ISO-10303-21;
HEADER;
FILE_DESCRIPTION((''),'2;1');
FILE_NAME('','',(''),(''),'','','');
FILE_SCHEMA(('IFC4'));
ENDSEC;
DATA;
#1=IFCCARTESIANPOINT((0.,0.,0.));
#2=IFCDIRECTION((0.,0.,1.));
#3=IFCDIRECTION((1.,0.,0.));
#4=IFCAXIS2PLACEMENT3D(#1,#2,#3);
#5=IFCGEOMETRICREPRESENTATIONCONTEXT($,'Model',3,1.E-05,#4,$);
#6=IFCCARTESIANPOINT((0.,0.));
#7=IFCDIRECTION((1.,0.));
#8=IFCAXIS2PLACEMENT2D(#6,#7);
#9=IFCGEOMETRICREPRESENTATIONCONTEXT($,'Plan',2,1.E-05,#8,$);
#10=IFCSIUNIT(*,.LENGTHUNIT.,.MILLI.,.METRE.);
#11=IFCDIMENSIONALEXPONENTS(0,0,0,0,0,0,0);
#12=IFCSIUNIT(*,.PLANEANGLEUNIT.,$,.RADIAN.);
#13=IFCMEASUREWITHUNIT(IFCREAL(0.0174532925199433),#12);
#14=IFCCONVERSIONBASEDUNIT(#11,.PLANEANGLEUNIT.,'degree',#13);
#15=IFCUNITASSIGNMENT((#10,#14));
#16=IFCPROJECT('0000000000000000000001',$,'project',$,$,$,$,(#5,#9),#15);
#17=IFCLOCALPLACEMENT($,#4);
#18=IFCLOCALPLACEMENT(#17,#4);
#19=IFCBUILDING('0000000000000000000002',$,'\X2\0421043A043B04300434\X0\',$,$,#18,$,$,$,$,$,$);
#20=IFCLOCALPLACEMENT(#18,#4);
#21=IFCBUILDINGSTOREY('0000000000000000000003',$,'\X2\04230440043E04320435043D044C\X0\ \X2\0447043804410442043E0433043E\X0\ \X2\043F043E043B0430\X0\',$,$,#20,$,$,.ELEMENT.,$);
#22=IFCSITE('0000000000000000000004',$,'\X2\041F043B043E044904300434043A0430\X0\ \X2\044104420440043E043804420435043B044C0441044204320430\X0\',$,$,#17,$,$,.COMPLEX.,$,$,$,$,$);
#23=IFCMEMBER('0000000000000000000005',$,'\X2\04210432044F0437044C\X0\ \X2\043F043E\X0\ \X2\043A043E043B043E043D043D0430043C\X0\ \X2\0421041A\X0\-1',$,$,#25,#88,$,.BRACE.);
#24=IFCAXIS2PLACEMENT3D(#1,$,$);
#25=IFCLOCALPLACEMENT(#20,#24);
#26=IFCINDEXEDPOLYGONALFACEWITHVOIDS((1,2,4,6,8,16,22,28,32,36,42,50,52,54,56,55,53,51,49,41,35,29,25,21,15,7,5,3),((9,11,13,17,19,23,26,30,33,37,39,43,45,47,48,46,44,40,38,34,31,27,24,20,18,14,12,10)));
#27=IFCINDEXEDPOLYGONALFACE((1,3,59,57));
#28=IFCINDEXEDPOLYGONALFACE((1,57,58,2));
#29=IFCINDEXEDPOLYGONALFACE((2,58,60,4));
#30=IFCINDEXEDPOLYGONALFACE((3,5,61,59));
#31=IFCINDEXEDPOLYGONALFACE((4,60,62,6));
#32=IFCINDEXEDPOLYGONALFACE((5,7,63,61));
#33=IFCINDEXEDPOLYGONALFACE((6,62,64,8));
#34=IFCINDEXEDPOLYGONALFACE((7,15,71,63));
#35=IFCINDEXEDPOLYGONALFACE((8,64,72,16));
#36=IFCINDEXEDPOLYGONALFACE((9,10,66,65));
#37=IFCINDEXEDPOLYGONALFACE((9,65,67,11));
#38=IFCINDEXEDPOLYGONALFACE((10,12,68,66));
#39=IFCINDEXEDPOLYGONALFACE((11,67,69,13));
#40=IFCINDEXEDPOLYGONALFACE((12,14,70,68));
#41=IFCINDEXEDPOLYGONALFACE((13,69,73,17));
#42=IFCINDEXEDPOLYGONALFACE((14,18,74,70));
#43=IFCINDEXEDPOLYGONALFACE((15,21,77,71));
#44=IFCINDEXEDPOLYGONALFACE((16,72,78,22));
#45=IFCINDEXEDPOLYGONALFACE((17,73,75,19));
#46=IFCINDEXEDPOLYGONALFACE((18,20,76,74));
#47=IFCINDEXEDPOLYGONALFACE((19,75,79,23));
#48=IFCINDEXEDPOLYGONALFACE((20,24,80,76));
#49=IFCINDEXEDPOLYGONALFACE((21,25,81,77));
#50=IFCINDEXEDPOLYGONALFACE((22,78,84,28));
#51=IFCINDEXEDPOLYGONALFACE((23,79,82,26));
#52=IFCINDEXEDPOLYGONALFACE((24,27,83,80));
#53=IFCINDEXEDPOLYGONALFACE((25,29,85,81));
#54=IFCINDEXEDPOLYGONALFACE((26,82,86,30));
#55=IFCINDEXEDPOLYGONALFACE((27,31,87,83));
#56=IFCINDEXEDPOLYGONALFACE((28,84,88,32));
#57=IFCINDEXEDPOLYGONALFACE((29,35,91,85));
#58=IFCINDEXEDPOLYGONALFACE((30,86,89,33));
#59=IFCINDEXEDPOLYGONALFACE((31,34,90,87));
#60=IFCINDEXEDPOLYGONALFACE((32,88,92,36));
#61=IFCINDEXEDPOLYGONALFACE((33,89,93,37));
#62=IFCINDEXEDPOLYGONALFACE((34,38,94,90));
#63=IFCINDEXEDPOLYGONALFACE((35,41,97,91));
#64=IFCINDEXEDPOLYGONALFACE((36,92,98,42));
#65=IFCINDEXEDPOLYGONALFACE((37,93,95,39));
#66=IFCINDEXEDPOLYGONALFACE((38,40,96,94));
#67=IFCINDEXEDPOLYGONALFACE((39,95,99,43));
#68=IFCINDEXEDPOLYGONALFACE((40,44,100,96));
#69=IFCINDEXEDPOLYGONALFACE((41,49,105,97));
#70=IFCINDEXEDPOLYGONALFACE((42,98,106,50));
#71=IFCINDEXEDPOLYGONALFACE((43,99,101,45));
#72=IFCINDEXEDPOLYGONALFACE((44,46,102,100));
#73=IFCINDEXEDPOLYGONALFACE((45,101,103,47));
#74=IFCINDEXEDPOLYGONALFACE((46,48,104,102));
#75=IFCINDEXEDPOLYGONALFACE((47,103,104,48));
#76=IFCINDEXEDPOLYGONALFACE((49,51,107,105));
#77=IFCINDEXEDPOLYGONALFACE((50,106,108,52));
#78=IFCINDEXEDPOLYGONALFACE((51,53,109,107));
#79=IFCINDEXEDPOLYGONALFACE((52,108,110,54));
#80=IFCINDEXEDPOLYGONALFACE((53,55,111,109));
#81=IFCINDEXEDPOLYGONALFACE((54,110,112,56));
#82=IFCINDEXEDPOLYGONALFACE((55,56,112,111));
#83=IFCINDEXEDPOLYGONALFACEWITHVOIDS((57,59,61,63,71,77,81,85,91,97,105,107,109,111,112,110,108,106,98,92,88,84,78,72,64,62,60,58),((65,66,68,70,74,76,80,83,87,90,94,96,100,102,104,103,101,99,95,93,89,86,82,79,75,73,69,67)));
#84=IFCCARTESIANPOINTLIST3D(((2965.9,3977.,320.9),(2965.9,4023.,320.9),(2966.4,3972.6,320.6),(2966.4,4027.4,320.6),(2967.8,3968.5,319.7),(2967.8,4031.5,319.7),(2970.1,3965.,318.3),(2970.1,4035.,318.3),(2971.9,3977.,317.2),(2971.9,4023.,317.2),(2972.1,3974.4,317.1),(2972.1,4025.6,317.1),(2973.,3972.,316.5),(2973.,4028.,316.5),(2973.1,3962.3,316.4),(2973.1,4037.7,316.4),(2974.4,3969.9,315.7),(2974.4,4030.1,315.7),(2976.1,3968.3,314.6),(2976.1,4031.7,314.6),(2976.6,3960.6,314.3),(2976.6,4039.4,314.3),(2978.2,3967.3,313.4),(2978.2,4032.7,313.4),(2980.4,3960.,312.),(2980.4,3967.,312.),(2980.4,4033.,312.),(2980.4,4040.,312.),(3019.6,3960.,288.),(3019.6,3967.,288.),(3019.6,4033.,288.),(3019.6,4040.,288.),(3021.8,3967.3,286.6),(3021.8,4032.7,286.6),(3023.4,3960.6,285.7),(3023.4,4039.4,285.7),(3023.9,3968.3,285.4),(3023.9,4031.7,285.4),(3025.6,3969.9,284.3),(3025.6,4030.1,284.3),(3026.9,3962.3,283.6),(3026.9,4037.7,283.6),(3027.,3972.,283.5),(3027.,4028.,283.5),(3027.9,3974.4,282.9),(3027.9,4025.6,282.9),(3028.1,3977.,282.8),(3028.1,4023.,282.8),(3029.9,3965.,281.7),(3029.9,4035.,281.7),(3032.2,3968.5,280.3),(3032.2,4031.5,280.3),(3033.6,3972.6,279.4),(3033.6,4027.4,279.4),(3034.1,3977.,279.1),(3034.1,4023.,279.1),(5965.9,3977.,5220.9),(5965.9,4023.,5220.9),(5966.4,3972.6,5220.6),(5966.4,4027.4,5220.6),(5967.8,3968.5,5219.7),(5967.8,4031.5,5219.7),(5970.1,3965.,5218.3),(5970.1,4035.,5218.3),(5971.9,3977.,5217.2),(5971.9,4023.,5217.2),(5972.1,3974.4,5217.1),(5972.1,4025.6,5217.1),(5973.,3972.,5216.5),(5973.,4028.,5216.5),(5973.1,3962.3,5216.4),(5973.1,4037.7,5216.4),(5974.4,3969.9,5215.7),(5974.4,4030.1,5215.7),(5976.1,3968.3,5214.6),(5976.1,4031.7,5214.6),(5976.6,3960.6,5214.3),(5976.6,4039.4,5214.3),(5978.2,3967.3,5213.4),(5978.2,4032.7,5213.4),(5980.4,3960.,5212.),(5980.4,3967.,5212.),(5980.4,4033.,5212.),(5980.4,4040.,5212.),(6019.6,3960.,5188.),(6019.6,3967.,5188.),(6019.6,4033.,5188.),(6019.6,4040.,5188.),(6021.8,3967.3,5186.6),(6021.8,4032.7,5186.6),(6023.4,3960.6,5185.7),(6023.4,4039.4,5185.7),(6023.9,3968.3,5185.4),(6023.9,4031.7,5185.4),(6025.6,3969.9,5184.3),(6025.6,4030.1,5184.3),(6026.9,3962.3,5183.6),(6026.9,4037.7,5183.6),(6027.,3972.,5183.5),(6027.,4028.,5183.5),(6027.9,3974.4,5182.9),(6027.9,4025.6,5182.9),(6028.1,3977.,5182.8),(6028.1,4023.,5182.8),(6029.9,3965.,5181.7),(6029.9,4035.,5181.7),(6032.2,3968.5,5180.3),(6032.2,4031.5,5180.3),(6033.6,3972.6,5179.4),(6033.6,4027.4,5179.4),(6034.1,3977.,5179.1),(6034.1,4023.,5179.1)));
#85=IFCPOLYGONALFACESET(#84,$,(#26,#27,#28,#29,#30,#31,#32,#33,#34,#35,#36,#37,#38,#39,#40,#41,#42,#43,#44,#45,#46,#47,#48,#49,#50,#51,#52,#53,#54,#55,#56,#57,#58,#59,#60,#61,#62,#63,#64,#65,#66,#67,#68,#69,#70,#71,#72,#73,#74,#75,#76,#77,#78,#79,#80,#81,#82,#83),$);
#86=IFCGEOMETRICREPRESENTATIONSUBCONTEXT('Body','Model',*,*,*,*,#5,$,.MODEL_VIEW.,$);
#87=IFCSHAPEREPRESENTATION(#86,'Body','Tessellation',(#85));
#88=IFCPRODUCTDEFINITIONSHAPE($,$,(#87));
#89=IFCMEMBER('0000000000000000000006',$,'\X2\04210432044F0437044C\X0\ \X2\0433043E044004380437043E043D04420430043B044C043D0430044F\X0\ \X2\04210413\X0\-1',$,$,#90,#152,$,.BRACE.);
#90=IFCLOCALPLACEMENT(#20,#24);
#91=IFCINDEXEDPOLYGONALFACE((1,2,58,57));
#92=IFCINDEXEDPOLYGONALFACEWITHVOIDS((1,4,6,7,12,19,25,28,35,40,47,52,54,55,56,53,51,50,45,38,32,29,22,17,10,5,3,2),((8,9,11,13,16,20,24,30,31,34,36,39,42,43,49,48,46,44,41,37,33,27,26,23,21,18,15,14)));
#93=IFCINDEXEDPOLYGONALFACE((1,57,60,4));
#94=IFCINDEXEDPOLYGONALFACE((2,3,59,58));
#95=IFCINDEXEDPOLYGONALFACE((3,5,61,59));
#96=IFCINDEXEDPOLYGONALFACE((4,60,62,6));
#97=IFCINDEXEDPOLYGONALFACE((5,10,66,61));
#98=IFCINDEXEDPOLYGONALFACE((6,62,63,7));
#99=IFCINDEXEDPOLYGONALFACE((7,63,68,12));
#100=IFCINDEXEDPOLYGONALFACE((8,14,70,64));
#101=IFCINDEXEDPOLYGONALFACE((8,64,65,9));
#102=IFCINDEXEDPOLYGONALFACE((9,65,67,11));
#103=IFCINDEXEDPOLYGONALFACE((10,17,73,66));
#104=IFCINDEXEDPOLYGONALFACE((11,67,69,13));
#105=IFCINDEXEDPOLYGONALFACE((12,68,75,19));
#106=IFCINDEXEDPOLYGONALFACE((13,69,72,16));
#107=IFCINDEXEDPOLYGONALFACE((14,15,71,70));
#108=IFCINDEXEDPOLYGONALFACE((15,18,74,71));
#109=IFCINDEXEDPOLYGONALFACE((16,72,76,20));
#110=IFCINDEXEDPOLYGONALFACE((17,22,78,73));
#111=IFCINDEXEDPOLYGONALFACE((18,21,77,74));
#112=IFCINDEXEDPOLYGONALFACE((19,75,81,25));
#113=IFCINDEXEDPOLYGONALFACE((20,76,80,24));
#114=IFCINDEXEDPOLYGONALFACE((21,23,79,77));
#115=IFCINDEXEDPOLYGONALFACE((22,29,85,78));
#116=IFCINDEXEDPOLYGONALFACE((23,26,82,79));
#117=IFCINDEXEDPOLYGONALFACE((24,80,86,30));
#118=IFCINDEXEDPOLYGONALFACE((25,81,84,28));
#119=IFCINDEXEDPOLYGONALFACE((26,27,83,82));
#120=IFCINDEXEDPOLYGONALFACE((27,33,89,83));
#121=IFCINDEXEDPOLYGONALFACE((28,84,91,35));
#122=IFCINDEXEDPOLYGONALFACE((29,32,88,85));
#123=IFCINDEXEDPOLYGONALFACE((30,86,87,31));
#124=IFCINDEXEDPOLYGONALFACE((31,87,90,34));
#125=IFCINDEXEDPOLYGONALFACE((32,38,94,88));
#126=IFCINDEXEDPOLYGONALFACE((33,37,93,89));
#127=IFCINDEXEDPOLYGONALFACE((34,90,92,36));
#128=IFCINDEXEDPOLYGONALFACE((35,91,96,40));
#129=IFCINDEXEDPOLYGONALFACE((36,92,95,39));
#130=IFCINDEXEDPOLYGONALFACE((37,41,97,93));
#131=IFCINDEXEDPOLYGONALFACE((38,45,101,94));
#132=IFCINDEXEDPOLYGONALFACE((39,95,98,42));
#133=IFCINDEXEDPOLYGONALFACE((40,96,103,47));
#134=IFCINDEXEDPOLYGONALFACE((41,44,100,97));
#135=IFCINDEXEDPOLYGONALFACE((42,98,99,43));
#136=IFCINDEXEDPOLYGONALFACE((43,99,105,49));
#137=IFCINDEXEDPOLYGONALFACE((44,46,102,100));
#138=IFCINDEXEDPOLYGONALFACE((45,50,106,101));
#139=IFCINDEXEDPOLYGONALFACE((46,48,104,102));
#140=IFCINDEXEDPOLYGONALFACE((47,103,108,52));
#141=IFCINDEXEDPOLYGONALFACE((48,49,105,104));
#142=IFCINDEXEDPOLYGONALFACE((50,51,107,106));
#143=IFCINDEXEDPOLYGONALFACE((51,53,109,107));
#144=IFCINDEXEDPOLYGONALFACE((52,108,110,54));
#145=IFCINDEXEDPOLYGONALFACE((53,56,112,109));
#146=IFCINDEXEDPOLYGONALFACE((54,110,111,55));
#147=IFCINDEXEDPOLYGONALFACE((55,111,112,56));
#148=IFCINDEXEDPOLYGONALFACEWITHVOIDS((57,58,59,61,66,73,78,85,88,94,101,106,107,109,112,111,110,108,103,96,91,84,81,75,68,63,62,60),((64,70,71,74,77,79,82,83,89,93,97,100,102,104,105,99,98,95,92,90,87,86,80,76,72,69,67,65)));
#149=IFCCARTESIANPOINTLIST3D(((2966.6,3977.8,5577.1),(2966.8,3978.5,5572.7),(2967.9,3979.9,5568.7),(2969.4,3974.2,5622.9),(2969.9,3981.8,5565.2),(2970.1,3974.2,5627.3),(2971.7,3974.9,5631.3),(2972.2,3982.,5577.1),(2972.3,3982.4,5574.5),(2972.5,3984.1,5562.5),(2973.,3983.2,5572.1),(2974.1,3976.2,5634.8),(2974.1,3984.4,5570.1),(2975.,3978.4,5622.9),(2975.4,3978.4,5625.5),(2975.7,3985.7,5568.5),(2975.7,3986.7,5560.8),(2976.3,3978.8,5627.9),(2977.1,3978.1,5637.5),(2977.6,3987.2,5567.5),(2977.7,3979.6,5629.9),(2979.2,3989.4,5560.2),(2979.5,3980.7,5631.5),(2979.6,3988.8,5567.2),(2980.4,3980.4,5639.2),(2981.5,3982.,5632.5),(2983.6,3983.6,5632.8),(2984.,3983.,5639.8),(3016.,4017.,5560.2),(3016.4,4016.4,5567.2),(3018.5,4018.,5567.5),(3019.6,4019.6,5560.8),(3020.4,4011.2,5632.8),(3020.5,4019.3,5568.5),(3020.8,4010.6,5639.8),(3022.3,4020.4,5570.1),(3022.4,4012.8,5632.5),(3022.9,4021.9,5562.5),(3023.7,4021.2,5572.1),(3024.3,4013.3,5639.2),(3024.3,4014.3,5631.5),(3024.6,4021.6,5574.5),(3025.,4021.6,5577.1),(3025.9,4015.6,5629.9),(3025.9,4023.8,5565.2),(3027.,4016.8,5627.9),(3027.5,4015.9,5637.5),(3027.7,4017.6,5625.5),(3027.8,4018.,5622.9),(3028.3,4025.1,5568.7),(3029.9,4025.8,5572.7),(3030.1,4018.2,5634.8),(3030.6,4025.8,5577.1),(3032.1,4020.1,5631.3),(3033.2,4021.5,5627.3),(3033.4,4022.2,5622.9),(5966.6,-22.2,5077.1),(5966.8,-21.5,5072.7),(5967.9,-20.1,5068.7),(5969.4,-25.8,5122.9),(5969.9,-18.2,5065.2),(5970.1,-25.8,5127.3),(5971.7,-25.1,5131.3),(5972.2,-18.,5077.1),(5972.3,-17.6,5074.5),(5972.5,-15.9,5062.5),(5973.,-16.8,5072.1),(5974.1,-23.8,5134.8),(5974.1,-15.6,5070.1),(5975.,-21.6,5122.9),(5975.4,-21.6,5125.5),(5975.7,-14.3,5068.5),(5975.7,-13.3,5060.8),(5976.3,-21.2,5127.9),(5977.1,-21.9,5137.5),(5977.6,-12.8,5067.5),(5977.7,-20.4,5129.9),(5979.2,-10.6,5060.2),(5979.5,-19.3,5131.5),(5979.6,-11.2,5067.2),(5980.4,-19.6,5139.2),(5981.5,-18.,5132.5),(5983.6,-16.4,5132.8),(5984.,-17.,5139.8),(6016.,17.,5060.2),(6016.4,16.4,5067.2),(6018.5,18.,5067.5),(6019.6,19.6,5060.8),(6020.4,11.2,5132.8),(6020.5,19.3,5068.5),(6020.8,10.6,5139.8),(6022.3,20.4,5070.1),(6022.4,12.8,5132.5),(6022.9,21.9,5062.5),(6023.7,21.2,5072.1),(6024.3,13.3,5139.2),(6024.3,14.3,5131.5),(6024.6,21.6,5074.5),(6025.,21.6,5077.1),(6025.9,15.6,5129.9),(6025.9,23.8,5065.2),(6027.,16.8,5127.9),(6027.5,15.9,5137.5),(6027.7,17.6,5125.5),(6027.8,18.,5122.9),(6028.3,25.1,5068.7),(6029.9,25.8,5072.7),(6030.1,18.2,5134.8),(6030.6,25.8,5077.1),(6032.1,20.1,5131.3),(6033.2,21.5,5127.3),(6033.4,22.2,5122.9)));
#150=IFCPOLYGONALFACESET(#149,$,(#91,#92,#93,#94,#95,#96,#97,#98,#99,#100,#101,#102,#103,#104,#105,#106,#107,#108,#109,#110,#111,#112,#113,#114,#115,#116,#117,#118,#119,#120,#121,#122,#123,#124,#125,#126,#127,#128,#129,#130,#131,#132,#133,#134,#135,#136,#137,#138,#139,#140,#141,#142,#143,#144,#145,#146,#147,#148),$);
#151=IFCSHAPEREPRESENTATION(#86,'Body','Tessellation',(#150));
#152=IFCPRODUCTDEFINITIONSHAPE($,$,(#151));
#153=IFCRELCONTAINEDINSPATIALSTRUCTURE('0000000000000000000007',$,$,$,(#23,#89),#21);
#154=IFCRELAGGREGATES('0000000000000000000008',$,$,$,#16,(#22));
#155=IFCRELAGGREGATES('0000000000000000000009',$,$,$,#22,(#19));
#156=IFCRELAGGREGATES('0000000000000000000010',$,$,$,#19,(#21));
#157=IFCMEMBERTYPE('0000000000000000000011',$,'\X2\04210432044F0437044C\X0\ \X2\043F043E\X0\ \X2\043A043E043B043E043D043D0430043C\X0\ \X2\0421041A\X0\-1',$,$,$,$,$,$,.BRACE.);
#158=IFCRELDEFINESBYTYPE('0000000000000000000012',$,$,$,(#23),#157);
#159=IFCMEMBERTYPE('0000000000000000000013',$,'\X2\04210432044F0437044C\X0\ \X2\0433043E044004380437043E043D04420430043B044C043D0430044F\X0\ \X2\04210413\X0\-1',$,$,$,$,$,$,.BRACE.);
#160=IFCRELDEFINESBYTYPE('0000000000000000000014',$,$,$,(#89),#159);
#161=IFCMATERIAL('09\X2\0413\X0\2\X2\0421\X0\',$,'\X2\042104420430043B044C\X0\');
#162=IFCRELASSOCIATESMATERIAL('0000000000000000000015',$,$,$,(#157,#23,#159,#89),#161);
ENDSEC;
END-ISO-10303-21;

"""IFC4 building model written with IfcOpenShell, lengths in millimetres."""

from ifc_helpers import new_model, entity, si_unit, converted_unit, frame, origin_with_axes, origin_2d_with_axis, place, context, subcontext, project, spatial, hollow_rectangle, extrude, material, material_profile, profile_set, profile_usage, type_object, element, save


model = new_model("IFC4")

# Units and contexts
model_context = context("Model", 3, precision=1e-05, world=origin_with_axes())
plan_context = context("Plan", 2, precision=1e-05, world=origin_2d_with_axis())
body_context = subcontext(model_context, "Body", "Model", "MODEL_VIEW")
ifc_project = project(units=[si_unit("LENGTHUNIT", "METRE", prefix="MILLI"), converted_unit("PLANEANGLEUNIT", "degree", entity("IfcReal", 0.0174532925199433), si_unit("PLANEANGLEUNIT", "RADIAN"), dimensions=[0, 0, 0, 0, 0, 0, 0])], contexts=[model_context, plan_context])

# Site, building, storey
site_placement = place(None, origin_with_axes())
site = spatial("IfcSite", under=ifc_project, at=site_placement, Name="Площадка строительства", CompositionType="COMPLEX")
building_placement = place(site_placement, origin_with_axes())
building = spatial("IfcBuilding", under=site, at=building_placement, Name="Склад")
storey_placement = place(building_placement, origin_with_axes())
storey = spatial("IfcBuildingStorey", under=building, at=storey_placement, Name="Уровень чистого пола", CompositionType="ELEMENT")

# Members
ifc_material_1 = material(Name="09Г2С", Category="Сталь")
ifc_material_profile_1 = material_profile(ifc_material_1, hollow_rectangle(XDim=80.0, YDim=80.0, WallThickness=7.0, InnerFilletRadius=10.0, OuterFilletRadius=17.0))
ifc_profile_set_1 = profile_set([ifc_material_profile_1], Name="PK80x7_09G2S")
member_type_1 = type_object("IfcMemberType", Name="Связь по колоннам СК-1", PredefinedType="BRACE", material=ifc_profile_set_1)
ifc_profile_usage_1 = profile_usage(ifc_profile_set_1, cardinal=5)
member_1_placement = place(storey_placement, frame((3000.0, 4000.0, 300.0), z_axis=(0.522154, 0.0, 0.852851), x_axis=(0.0, 1.0, 0.0)))
element("IfcMember", 1, at=member_1_placement, inside=storey, type_object=member_type_1, material=ifc_profile_usage_1, Name="Связь по колоннам СК-1", PredefinedType="BRACE", context=body_context, shape_type="SweptSolid", body=[
    extrude(hollow_rectangle(XDim=80.0, YDim=80.0, WallThickness=7.0, InnerFilletRadius=10.0, OuterFilletRadius=17.0), origin_with_axes(), (0.0, 0.0, 1.0), 5745.4),
])
ifc_material_profile_2 = material_profile(ifc_material_1, hollow_rectangle(XDim=80.0, YDim=80.0, WallThickness=7.0, InnerFilletRadius=10.0, OuterFilletRadius=17.0))
ifc_profile_set_2 = profile_set([ifc_material_profile_2], Name="PK80x7_09G2S")
ifc_profile_usage_2 = profile_usage(ifc_profile_set_2, cardinal=5)
member_type_2 = type_object("IfcMemberType", Name="Связь горизонтальная СГ-1", PredefinedType="BRACE", material=ifc_profile_set_2)
member_2_placement = place(storey_placement, frame((6000.0, 0.0, 5100.0), z_axis=(-0.597022, 0.79603, 0.099504), x_axis=(-0.8, -0.6, 0.0)))
element("IfcMember", 2, at=member_2_placement, inside=storey, type_object=member_type_2, material=ifc_profile_usage_2, Name="Связь горизонтальная СГ-1", PredefinedType="BRACE", context=body_context, shape_type="SweptSolid", body=[
    extrude(hollow_rectangle(XDim=80.0, YDim=80.0, WallThickness=7.0, InnerFilletRadius=10.0, OuterFilletRadius=17.0), origin_with_axes(), (0.0, 0.0, 1.0), 5024.9),
])

save(model, "model.ifc")
